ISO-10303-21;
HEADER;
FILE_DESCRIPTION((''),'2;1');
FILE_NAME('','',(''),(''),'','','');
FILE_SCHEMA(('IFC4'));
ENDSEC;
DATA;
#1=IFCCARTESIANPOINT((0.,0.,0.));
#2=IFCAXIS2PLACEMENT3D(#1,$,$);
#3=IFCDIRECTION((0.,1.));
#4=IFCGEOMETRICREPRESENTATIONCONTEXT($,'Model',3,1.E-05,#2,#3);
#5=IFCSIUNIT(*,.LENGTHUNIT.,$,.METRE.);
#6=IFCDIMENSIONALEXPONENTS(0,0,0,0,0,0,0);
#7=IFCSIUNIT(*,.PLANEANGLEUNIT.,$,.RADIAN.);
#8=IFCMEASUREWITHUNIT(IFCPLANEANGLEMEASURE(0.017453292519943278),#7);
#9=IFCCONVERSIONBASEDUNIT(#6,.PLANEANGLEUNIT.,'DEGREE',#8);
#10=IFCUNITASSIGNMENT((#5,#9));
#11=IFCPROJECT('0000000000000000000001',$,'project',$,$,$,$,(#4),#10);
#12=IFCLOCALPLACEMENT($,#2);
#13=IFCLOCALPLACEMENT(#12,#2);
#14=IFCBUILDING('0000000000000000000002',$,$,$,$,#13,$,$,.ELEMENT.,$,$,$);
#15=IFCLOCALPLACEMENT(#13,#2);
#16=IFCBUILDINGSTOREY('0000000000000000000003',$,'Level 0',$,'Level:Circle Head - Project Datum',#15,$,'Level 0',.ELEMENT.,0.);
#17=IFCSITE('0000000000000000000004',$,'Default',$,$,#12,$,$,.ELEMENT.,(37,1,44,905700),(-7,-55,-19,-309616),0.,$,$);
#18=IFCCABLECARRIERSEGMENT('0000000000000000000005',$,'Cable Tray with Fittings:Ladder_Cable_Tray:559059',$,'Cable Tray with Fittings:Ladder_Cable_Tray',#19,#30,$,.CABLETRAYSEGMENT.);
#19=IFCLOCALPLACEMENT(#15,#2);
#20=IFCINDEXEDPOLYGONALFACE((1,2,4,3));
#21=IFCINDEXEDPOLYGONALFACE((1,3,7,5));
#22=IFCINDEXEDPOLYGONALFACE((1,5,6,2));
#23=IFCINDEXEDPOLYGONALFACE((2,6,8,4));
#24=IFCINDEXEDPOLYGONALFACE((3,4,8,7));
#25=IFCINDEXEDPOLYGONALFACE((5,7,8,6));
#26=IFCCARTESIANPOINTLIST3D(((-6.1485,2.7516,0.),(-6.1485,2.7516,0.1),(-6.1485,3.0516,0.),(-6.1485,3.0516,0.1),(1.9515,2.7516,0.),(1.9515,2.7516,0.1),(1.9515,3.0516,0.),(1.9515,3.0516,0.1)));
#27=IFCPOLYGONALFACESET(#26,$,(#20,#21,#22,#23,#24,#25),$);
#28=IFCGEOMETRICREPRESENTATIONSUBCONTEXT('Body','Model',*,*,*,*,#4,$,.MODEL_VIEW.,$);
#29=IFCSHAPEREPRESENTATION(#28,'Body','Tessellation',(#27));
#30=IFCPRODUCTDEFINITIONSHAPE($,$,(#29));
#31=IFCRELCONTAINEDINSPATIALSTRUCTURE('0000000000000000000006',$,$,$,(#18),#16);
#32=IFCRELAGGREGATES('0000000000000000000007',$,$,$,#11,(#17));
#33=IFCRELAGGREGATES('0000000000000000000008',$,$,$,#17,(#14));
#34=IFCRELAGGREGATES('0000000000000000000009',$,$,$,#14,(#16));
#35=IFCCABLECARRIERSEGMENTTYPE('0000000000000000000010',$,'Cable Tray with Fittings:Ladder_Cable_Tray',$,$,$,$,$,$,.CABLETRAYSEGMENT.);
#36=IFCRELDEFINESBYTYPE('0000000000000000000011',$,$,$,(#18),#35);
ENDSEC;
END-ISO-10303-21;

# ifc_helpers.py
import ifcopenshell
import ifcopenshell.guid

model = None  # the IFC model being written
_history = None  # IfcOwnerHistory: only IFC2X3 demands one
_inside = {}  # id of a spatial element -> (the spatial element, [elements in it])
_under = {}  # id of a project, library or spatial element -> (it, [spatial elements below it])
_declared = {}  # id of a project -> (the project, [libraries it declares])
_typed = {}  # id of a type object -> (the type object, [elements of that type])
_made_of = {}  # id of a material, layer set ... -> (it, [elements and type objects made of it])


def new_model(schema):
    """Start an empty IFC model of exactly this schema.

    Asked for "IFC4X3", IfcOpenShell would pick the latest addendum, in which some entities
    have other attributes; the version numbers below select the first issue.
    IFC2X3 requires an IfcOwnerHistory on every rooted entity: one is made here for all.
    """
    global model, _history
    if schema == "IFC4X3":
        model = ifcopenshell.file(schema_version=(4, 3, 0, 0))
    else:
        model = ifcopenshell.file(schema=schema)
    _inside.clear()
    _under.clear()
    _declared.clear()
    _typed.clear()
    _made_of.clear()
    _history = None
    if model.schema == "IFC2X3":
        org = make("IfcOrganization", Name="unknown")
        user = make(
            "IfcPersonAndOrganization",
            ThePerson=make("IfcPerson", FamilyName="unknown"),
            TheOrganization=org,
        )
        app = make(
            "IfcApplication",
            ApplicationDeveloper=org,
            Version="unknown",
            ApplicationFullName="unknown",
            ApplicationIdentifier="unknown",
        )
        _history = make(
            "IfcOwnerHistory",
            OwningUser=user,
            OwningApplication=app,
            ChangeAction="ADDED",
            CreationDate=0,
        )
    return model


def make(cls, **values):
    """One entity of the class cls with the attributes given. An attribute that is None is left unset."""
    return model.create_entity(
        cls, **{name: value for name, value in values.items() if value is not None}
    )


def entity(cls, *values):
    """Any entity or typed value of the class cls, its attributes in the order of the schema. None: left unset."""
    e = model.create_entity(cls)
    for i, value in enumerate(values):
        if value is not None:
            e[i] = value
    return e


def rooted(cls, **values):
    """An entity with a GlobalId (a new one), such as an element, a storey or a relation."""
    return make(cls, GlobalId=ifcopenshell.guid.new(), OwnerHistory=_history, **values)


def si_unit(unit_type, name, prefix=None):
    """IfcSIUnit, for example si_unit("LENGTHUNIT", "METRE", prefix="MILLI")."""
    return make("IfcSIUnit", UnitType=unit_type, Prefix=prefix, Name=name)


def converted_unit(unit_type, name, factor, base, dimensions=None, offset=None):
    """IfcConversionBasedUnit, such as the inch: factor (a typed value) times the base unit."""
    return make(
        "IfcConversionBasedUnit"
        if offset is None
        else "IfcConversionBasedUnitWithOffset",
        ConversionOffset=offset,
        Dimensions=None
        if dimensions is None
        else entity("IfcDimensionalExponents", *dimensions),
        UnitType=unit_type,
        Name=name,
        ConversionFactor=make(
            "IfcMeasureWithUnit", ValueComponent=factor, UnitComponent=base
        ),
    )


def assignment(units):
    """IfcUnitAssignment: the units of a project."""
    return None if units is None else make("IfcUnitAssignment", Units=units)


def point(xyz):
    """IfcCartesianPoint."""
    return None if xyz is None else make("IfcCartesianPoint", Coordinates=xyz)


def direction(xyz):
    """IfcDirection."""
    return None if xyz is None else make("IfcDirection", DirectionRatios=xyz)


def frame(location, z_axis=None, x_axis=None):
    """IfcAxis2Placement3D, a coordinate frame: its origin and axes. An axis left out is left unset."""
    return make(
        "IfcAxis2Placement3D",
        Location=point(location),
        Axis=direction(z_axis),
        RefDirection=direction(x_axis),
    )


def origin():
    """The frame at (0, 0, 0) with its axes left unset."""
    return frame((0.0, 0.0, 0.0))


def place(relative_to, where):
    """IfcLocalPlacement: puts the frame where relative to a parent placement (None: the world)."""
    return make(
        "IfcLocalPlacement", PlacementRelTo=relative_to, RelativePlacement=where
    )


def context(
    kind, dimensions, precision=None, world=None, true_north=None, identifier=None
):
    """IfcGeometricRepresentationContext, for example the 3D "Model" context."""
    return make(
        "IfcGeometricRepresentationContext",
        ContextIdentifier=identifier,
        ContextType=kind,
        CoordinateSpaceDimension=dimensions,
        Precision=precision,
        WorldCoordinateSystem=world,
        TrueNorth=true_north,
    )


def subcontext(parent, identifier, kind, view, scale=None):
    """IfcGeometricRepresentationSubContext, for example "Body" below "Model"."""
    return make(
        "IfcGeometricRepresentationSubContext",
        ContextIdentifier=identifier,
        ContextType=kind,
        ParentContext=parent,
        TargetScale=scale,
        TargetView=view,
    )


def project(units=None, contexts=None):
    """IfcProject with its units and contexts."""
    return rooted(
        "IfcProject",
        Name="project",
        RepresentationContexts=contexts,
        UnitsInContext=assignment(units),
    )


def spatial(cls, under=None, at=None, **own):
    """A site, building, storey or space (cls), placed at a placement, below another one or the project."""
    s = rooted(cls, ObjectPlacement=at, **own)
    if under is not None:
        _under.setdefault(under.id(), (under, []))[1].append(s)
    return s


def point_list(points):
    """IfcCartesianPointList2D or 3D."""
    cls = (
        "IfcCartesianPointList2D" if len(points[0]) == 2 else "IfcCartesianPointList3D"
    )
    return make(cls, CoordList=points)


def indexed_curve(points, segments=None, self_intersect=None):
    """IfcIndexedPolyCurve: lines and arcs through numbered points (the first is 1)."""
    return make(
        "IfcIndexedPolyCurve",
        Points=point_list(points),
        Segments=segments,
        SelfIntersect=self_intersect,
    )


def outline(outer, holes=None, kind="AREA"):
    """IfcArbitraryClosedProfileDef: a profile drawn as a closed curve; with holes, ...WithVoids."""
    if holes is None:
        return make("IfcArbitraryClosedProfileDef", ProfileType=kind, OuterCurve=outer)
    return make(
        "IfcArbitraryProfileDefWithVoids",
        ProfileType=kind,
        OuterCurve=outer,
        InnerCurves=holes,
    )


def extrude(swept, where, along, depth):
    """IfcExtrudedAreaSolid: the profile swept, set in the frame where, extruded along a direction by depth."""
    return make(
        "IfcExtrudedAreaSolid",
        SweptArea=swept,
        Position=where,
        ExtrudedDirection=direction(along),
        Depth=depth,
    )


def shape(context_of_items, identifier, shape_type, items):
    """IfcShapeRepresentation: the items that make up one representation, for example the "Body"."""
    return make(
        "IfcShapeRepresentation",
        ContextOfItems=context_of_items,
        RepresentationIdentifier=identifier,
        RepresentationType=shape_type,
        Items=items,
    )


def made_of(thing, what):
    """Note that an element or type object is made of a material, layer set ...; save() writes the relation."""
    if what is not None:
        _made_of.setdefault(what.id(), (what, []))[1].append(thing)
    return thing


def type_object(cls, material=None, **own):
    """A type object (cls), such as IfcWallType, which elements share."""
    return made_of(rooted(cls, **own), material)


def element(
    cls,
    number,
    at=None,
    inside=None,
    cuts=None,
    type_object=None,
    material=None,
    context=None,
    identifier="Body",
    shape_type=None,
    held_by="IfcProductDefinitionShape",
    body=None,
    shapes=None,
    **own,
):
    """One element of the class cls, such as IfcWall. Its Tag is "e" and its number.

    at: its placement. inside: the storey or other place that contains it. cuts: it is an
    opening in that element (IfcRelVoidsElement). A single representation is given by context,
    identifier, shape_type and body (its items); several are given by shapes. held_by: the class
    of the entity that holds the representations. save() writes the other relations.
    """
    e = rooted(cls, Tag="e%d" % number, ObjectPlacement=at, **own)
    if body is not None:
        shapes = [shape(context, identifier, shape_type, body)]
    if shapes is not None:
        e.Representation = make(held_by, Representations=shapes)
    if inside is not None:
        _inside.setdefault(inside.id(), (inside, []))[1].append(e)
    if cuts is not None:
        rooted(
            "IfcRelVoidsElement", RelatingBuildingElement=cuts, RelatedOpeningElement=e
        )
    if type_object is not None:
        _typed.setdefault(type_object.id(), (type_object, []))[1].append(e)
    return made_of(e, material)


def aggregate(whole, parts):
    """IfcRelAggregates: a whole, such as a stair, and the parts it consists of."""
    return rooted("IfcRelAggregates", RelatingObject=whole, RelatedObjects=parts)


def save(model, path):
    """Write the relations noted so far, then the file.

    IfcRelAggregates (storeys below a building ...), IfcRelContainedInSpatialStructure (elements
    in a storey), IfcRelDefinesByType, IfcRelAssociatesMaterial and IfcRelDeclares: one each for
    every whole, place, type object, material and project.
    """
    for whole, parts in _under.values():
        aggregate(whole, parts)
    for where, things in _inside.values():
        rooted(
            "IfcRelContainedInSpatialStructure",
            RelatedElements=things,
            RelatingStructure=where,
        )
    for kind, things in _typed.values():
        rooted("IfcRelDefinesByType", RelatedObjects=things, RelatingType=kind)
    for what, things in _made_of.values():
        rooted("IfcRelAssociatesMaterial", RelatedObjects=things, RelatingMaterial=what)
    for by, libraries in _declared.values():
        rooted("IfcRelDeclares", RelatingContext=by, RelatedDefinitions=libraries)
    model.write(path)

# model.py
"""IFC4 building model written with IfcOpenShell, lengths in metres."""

from ifc_helpers import new_model, entity, si_unit, converted_unit, direction, frame, origin, place, context, subcontext, project, spatial, indexed_curve, outline, extrude, type_object, element, save


model = new_model("IFC4")

# Units and contexts
model_context = context("Model", 3, precision=1e-05, world=origin(), true_north=direction((0.0, 1.0)))
body_context = subcontext(model_context, "Body", "Model", "MODEL_VIEW")
ifc_project = project(units=[si_unit("LENGTHUNIT", "METRE"), converted_unit("PLANEANGLEUNIT", "DEGREE", entity("IfcPlaneAngleMeasure", 0.017453292519943278), si_unit("PLANEANGLEUNIT", "RADIAN"), dimensions=[0, 0, 0, 0, 0, 0, 0])], contexts=[model_context])

# Site, building, storey
site_placement = place(None, origin())
site = spatial("IfcSite", under=ifc_project, at=site_placement, Name="Default", CompositionType="ELEMENT", RefLatitude=(37, 1, 44, 905700), RefLongitude=(-7, -55, -19, -309616), RefElevation=0.0)
building_placement = place(site_placement, origin())
building = spatial("IfcBuilding", under=site, at=building_placement, CompositionType="ELEMENT")
storey_placement = place(building_placement, origin())
storey = spatial("IfcBuildingStorey", under=building, at=storey_placement, Name="Level 0", ObjectType="Level:Circle Head - Project Datum", LongName="Level 0", CompositionType="ELEMENT", Elevation=0.0)

# Cable carrier segment
cable_carrier_segment_type = type_object("IfcCableCarrierSegmentType", Name="Cable Tray with Fittings:Ladder_Cable_Tray", PredefinedType="CABLETRAYSEGMENT")
cable_carrier_segment_placement = place(storey_placement, origin())
element("IfcCableCarrierSegment", 1, at=cable_carrier_segment_placement, inside=storey, type_object=cable_carrier_segment_type, Name="Cable Tray with Fittings:Ladder_Cable_Tray:559059", ObjectType="Cable Tray with Fittings:Ladder_Cable_Tray", PredefinedType="CABLETRAYSEGMENT", context=body_context, shape_type="SweptSolid", body=[
    extrude(outline(indexed_curve([(-4.05, -0.15), (4.05, -0.15), (4.05, 0.15), (-4.05, 0.15), (-4.05, -0.15)], self_intersect=False)), frame((-2.0985, 2.9016, 0.0)), (0.0, 0.0, 1.0), 0.1),
])

save(model, "model.ifc")
